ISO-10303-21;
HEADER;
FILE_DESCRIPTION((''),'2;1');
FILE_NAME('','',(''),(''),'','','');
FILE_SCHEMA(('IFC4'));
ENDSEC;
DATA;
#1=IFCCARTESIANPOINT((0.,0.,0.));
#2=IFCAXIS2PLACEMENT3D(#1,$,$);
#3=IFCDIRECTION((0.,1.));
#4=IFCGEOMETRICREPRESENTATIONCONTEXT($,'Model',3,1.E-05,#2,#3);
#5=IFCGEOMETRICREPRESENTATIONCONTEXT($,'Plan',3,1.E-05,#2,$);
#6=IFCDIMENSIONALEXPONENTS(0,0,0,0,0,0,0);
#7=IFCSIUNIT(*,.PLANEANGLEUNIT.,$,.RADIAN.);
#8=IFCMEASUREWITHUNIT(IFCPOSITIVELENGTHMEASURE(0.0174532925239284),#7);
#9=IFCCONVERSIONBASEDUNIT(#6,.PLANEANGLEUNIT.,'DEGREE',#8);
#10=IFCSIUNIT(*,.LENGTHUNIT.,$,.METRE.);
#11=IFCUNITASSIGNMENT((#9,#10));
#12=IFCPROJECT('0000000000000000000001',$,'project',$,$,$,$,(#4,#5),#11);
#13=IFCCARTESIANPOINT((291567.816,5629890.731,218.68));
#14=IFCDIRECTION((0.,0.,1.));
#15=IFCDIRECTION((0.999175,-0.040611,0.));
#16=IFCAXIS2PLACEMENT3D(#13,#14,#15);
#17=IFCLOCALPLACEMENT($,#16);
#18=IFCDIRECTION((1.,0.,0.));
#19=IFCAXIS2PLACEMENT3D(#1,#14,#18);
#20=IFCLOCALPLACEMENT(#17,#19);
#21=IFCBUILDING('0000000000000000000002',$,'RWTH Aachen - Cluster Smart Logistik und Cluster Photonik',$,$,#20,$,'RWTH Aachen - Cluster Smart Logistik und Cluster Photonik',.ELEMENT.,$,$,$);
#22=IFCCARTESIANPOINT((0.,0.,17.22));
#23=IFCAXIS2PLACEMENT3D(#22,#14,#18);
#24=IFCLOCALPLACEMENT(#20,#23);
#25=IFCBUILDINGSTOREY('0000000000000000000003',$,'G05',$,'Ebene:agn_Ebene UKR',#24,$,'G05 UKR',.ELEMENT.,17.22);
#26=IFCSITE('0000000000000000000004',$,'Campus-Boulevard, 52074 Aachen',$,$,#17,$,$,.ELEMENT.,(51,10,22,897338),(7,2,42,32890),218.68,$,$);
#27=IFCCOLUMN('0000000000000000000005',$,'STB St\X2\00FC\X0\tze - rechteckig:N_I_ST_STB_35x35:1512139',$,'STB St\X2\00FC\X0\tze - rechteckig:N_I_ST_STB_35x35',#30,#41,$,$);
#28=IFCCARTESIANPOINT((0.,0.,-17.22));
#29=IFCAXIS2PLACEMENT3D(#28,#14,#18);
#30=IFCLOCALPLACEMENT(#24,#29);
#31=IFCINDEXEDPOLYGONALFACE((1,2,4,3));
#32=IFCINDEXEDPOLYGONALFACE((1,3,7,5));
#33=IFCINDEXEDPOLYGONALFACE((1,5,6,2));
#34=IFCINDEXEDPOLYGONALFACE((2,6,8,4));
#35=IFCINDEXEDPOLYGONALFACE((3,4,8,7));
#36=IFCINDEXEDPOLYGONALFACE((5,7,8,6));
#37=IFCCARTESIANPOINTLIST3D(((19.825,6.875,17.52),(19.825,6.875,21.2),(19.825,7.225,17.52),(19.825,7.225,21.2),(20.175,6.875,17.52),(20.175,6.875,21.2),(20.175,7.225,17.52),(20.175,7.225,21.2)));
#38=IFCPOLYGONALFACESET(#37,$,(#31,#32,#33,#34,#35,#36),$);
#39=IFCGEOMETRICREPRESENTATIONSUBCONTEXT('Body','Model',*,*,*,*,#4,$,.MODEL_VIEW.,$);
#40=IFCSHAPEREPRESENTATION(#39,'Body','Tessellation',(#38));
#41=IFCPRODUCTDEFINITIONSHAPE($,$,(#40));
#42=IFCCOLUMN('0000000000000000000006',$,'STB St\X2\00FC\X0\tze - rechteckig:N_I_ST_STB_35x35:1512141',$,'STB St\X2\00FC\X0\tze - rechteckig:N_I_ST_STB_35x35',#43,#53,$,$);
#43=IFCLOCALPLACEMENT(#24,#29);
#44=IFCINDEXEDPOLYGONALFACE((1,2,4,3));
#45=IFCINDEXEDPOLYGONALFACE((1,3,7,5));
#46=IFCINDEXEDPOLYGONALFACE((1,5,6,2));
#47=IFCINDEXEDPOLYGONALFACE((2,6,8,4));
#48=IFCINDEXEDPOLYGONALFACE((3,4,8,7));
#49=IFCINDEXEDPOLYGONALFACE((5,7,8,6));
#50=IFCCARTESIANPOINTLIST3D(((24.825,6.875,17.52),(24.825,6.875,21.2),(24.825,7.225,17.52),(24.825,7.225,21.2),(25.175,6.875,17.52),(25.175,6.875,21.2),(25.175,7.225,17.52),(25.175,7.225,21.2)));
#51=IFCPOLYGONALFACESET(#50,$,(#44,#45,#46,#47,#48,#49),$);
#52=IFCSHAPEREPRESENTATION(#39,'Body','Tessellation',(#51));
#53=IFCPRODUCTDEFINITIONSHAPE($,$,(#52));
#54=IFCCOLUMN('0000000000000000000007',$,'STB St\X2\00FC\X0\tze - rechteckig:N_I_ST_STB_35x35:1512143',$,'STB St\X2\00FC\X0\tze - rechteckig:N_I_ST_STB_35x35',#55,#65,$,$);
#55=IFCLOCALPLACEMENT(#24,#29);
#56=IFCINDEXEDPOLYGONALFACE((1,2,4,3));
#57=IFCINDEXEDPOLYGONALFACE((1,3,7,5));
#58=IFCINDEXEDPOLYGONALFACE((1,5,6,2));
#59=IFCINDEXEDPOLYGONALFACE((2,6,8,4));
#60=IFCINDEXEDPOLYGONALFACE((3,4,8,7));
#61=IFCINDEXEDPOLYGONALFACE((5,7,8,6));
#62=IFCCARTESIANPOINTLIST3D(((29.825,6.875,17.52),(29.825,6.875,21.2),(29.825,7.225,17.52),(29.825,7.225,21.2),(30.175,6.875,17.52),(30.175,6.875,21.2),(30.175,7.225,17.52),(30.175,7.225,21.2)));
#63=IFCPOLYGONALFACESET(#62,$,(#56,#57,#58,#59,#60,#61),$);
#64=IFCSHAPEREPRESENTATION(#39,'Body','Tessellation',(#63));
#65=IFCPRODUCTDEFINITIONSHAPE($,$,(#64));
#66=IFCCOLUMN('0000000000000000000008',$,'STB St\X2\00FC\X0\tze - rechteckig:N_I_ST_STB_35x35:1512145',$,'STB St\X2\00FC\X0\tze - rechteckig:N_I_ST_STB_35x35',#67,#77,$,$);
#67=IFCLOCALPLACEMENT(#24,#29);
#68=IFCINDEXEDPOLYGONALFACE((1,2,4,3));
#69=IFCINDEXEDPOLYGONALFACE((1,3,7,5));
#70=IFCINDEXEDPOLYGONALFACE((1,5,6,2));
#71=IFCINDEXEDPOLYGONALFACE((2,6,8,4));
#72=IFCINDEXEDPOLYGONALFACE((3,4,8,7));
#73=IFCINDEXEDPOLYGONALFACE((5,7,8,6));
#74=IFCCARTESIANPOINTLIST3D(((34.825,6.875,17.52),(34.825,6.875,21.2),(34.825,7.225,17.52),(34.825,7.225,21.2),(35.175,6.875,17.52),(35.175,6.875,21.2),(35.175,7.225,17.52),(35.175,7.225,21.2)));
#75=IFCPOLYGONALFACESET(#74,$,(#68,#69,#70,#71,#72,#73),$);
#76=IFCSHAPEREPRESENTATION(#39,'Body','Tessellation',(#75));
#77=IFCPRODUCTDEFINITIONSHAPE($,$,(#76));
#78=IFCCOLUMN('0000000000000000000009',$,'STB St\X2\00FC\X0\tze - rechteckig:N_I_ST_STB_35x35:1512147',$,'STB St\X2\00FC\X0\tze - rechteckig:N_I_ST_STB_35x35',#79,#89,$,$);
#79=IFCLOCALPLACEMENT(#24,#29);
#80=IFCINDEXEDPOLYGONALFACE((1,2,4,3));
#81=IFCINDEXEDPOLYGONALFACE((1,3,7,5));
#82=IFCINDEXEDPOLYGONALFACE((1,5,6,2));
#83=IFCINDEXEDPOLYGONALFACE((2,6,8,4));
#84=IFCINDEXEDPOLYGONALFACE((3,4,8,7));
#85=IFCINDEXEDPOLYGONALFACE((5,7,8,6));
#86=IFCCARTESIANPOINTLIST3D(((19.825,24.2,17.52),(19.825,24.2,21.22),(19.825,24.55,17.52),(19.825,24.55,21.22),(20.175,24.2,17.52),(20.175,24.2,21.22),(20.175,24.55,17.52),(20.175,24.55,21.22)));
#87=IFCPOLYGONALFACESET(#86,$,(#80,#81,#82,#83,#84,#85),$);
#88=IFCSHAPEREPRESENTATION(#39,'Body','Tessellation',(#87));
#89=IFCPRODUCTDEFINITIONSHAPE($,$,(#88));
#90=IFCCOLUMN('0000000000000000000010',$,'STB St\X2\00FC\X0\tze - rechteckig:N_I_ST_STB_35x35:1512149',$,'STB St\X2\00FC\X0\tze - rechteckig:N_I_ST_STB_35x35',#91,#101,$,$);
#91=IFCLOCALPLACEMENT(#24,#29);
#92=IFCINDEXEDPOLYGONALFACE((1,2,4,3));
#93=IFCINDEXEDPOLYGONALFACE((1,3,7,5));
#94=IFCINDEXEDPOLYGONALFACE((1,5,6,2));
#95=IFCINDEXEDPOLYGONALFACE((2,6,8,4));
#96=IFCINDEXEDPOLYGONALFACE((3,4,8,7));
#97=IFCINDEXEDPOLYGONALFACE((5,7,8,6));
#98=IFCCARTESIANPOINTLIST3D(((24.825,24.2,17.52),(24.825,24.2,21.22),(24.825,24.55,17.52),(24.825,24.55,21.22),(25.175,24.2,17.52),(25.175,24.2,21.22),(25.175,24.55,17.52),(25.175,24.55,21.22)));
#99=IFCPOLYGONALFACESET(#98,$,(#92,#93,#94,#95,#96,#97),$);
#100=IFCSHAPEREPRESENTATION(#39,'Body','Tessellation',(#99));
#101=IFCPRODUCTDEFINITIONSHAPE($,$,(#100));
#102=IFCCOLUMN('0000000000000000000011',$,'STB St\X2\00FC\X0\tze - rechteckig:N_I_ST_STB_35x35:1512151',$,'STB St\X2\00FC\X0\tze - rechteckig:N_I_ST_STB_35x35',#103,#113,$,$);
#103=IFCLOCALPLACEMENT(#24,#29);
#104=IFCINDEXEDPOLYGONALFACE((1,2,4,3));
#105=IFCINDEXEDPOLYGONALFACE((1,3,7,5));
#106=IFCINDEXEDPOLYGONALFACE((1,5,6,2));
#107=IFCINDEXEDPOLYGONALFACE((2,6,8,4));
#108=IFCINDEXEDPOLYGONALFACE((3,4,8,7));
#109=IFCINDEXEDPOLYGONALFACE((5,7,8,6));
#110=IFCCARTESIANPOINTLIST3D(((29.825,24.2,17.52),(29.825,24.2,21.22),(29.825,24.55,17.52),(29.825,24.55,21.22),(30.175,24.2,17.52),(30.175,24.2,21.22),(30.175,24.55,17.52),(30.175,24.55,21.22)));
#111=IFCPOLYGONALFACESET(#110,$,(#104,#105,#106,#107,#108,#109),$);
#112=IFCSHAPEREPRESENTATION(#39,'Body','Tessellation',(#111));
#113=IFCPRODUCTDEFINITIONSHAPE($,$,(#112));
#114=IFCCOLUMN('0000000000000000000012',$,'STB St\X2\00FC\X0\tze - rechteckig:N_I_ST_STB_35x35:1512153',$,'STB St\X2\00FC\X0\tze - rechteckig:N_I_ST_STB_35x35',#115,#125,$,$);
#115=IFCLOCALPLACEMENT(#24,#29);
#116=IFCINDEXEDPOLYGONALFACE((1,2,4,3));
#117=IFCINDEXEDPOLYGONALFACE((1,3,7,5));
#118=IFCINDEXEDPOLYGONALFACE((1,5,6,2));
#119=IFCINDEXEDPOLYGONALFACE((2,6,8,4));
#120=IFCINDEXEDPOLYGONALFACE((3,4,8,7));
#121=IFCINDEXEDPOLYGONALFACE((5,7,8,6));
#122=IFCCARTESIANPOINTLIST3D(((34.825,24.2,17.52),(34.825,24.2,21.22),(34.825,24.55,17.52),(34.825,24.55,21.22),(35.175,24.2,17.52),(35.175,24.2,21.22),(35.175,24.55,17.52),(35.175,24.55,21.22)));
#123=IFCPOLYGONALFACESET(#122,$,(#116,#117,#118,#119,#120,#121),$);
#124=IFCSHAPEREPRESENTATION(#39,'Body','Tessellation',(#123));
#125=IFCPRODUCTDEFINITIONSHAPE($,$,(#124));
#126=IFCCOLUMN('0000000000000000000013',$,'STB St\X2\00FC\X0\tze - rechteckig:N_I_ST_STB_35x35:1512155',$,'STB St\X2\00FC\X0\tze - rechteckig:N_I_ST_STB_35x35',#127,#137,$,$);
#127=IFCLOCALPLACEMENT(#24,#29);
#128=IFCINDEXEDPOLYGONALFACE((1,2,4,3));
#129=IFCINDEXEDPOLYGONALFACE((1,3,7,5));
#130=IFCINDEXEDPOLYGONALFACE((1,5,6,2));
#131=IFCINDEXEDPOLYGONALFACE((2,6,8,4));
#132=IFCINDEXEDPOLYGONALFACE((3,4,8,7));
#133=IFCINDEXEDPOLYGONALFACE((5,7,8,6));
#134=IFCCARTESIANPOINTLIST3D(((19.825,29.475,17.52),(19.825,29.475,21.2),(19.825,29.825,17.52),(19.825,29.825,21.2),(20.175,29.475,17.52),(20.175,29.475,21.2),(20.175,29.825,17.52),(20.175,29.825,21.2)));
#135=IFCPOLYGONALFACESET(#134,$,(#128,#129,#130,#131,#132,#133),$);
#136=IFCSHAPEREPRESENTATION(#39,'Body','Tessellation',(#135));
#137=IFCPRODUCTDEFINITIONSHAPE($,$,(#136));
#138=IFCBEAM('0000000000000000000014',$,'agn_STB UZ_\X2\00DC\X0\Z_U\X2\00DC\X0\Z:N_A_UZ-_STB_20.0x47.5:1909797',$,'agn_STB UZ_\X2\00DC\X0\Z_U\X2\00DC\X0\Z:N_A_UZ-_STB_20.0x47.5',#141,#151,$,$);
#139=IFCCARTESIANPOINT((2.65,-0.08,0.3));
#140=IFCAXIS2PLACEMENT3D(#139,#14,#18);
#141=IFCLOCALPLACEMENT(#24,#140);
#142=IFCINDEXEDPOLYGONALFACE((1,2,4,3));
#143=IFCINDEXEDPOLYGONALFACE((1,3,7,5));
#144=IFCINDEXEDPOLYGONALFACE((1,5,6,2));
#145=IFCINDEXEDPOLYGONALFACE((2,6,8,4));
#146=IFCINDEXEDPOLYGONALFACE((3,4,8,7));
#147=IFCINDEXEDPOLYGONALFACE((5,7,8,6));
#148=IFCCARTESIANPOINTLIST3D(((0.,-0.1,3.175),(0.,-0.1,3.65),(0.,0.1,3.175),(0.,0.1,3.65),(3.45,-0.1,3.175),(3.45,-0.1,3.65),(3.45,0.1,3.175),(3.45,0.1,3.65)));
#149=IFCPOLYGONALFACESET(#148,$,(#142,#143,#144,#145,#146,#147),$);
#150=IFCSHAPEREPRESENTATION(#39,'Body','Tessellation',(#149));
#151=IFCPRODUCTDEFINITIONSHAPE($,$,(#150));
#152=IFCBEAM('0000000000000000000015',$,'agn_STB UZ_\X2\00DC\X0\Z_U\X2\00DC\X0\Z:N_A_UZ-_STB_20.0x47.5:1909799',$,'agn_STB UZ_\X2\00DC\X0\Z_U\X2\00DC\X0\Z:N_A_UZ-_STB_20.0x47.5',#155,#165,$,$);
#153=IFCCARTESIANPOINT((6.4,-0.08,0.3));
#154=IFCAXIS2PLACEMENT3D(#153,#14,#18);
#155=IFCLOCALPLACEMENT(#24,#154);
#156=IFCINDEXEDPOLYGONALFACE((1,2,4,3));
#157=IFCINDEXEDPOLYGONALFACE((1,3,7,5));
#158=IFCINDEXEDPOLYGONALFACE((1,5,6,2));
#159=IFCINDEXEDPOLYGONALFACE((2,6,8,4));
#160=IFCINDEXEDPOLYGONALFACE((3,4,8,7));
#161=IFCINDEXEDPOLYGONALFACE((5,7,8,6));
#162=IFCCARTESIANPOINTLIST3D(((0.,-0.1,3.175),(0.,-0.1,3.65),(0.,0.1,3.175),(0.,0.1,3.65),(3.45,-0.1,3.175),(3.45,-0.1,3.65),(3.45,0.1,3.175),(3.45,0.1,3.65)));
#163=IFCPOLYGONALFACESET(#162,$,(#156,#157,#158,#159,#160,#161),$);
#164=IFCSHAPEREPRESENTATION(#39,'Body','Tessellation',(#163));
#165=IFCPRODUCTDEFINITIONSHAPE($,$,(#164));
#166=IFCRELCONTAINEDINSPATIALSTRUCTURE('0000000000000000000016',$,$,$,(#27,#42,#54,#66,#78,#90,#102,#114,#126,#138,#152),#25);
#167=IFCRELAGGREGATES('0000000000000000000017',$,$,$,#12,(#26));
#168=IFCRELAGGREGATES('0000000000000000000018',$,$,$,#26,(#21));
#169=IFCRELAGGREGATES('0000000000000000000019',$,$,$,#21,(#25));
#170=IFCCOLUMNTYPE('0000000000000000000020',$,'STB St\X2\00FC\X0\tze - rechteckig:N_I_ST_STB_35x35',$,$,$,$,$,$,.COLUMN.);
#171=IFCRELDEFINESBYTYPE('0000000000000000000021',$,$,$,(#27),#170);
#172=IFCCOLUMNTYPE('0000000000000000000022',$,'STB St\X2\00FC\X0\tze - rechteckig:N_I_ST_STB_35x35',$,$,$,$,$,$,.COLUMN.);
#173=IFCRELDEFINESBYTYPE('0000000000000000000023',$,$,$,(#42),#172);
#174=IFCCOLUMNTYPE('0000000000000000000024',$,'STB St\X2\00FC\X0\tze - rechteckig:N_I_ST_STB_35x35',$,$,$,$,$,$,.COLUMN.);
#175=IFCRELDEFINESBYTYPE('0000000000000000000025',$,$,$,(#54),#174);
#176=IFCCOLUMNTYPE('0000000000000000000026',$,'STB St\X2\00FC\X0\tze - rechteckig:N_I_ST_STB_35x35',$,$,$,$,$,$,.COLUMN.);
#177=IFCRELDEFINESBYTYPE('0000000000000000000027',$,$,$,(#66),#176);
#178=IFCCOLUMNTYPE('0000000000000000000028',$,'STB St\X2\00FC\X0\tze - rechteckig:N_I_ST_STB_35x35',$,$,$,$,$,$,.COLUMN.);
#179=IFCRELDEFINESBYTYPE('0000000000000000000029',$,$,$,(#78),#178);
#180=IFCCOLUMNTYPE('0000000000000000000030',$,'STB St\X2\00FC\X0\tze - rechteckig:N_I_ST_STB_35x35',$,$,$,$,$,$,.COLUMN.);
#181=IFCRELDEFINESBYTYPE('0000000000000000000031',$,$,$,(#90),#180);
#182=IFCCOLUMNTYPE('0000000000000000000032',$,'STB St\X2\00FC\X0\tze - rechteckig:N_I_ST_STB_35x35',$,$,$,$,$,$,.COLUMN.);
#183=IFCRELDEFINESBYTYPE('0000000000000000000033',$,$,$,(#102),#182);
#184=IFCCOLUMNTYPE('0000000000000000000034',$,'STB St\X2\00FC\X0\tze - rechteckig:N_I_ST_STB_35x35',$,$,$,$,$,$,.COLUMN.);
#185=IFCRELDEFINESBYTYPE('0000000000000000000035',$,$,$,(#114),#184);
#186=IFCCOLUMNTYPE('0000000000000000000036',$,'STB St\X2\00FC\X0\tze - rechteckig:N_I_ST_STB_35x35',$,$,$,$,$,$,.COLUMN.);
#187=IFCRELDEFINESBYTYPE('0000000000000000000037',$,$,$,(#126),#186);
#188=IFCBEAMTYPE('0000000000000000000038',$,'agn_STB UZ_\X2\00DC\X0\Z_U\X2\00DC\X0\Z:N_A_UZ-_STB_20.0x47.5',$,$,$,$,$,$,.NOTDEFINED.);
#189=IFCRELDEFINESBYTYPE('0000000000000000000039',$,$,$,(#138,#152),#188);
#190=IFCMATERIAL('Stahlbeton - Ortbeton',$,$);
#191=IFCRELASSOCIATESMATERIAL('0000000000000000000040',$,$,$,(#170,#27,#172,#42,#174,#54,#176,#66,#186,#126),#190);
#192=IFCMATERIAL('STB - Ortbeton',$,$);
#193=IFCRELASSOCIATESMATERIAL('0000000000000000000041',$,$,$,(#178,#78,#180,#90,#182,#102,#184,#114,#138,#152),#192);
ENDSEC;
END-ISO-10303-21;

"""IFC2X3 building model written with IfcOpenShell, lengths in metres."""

from ifc_helpers import new_model, entity, si_unit, converted_unit, direction, frame, frame_2d, origin, origin_with_axes, origin_2d_with_axis, place, context, subcontext, project, spatial, rectangle, extrude, source, transform, mapped, material, type_object, element, save


model = new_model("IFC2X3")

# Units and contexts
model_context = context("Model", 3, precision=1e-05, world=origin(), true_north=direction((0.0, 1.0)))
plan_context = context("Plan", 3, precision=1e-05, world=origin())
body_context = subcontext(model_context, "Body", "Model", "MODEL_VIEW")
ifc_project = project(units=[converted_unit("PLANEANGLEUNIT", "DEGREE", entity("IfcPositiveLengthMeasure", 0.0174532925239284), si_unit("PLANEANGLEUNIT", "RADIAN"), dimensions=[0, 0, 0, 0, 0, 0, 0]), si_unit("LENGTHUNIT", "METRE")], contexts=[model_context, plan_context])

# Site, building, storey
site_placement = place(None, frame((291567.816, 5629890.731, 218.68), z_axis=(0.0, 0.0, 1.0), x_axis=(0.999175, -0.040611, 0.0)))
site = spatial("IfcSite", under=ifc_project, at=site_placement, Name="Campus-Boulevard, 52074 Aachen", CompositionType="ELEMENT", RefLatitude=(51, 10, 22, 897338), RefLongitude=(7, 2, 42, 32890), RefElevation=218.68)
building_placement = place(site_placement, origin_with_axes())
building = spatial("IfcBuilding", under=site, at=building_placement, Name="RWTH Aachen - Cluster Smart Logistik und Cluster Photonik", LongName="RWTH Aachen - Cluster Smart Logistik und Cluster Photonik", CompositionType="ELEMENT")
storey_placement = place(building_placement, frame((0.0, 0.0, 17.22), z_axis=(0.0, 0.0, 1.0), x_axis=(1.0, 0.0, 0.0)))
storey = spatial("IfcBuildingStorey", under=building, at=storey_placement, Name="G05", ObjectType="Ebene:agn_Ebene UKR", LongName="G05 UKR", CompositionType="ELEMENT", Elevation=17.22)

# Columns
ifc_material_1 = material(Name="STB - Ortbeton")
ifc_material_2 = material(Name="Stahlbeton - Ortbeton")
column_type_1 = type_object("IfcColumnType", Name="STB Stütze - rechteckig:N_I_ST_STB_35x35", PredefinedType="COLUMN", material=ifc_material_2)
shared_shape_1 = source(origin(), body_context, "Body", "SweptSolid", [
    extrude(rectangle(XDim=0.35, YDim=0.35, at=origin_2d_with_axis()), frame((20.0, 7.05, 17.52), z_axis=(0.0, 0.0, 1.0), x_axis=(0.0, -1.0, 0.0)), (0.0, 0.0, 1.0), 3.68),
])
column_1_placement = place(storey_placement, frame((0.0, 0.0, -17.22), z_axis=(0.0, 0.0, 1.0), x_axis=(1.0, 0.0, 0.0)))
element("IfcColumn", 1, at=column_1_placement, inside=storey, type_object=column_type_1, material=ifc_material_2, Name="STB Stütze - rechteckig:N_I_ST_STB_35x35:1512139", ObjectType="STB Stütze - rechteckig:N_I_ST_STB_35x35", context=body_context, shape_type="MappedRepresentation", body=[
    mapped(shared_shape_1, transform((0.0, 0.0, 0.0), scale=1.0)),
])
column_type_2 = type_object("IfcColumnType", Name="STB Stütze - rechteckig:N_I_ST_STB_35x35", PredefinedType="COLUMN", material=ifc_material_2)
shared_shape_2 = source(origin(), body_context, "Body", "SweptSolid", [
    extrude(rectangle(XDim=0.35, YDim=0.35, at=origin_2d_with_axis()), frame((25.0, 7.05, 17.52), z_axis=(0.0, 0.0, 1.0), x_axis=(0.0, -1.0, 0.0)), (0.0, 0.0, 1.0), 3.68),
])
column_2_placement = place(storey_placement, frame((0.0, 0.0, -17.22), z_axis=(0.0, 0.0, 1.0), x_axis=(1.0, 0.0, 0.0)))
element("IfcColumn", 2, at=column_2_placement, inside=storey, type_object=column_type_2, material=ifc_material_2, Name="STB Stütze - rechteckig:N_I_ST_STB_35x35:1512141", ObjectType="STB Stütze - rechteckig:N_I_ST_STB_35x35", context=body_context, shape_type="MappedRepresentation", body=[
    mapped(shared_shape_2, transform((0.0, 0.0, 0.0), scale=1.0)),
])
column_type_3 = type_object("IfcColumnType", Name="STB Stütze - rechteckig:N_I_ST_STB_35x35", PredefinedType="COLUMN", material=ifc_material_2)
shared_shape_3 = source(origin(), body_context, "Body", "SweptSolid", [
    extrude(rectangle(XDim=0.35, YDim=0.35, at=origin_2d_with_axis()), frame((30.0, 7.05, 17.52), z_axis=(0.0, 0.0, 1.0), x_axis=(0.0, -1.0, 0.0)), (0.0, 0.0, 1.0), 3.68),
])
column_3_placement = place(storey_placement, frame((0.0, 0.0, -17.22), z_axis=(0.0, 0.0, 1.0), x_axis=(1.0, 0.0, 0.0)))
element("IfcColumn", 3, at=column_3_placement, inside=storey, type_object=column_type_3, material=ifc_material_2, Name="STB Stütze - rechteckig:N_I_ST_STB_35x35:1512143", ObjectType="STB Stütze - rechteckig:N_I_ST_STB_35x35", context=body_context, shape_type="MappedRepresentation", body=[
    mapped(shared_shape_3, transform((0.0, 0.0, 0.0), scale=1.0)),
])
column_type_4 = type_object("IfcColumnType", Name="STB Stütze - rechteckig:N_I_ST_STB_35x35", PredefinedType="COLUMN", material=ifc_material_2)
shared_shape_4 = source(origin(), body_context, "Body", "SweptSolid", [
    extrude(rectangle(XDim=0.35, YDim=0.35, at=frame_2d((0.0, 0.0), x_axis=(1.0, 0.0))), frame((35.0, 7.05, 17.52), z_axis=(0.0, 0.0, 1.0), x_axis=(0.0, -1.0, 0.0)), (0.0, 0.0, 1.0), 3.68),
])
column_4_placement = place(storey_placement, frame((0.0, 0.0, -17.22), z_axis=(0.0, 0.0, 1.0), x_axis=(1.0, 0.0, 0.0)))
element("IfcColumn", 4, at=column_4_placement, inside=storey, type_object=column_type_4, material=ifc_material_2, Name="STB Stütze - rechteckig:N_I_ST_STB_35x35:1512145", ObjectType="STB Stütze - rechteckig:N_I_ST_STB_35x35", context=body_context, shape_type="MappedRepresentation", body=[
    mapped(shared_shape_4, transform((0.0, 0.0, 0.0), scale=1.0)),
])
column_type_5 = type_object("IfcColumnType", Name="STB Stütze - rechteckig:N_I_ST_STB_35x35", PredefinedType="COLUMN", material=ifc_material_1)
shared_shape_5 = source(origin(), body_context, "Body", "SweptSolid", [
    extrude(rectangle(XDim=0.35, YDim=0.35, at=origin_2d_with_axis()), frame((20.0, 24.375, 17.52), z_axis=(0.0, 0.0, 1.0), x_axis=(0.0, -1.0, 0.0)), (0.0, 0.0, 1.0), 3.7),
])
column_5_placement = place(storey_placement, frame((0.0, 0.0, -17.22), z_axis=(0.0, 0.0, 1.0), x_axis=(1.0, 0.0, 0.0)))
element("IfcColumn", 5, at=column_5_placement, inside=storey, type_object=column_type_5, material=ifc_material_1, Name="STB Stütze - rechteckig:N_I_ST_STB_35x35:1512147", ObjectType="STB Stütze - rechteckig:N_I_ST_STB_35x35", context=body_context, shape_type="MappedRepresentation", body=[
    mapped(shared_shape_5, transform((0.0, 0.0, 0.0), scale=1.0)),
])
column_type_6 = type_object("IfcColumnType", Name="STB Stütze - rechteckig:N_I_ST_STB_35x35", PredefinedType="COLUMN", material=ifc_material_1)
shared_shape_6 = source(origin(), body_context, "Body", "SweptSolid", [
    extrude(rectangle(XDim=0.35, YDim=0.35, at=origin_2d_with_axis()), frame((25.0, 24.375, 17.52), z_axis=(0.0, 0.0, 1.0), x_axis=(0.0, -1.0, 0.0)), (0.0, 0.0, 1.0), 3.7),
])
column_6_placement = place(storey_placement, frame((0.0, 0.0, -17.22), z_axis=(0.0, 0.0, 1.0), x_axis=(1.0, 0.0, 0.0)))
element("IfcColumn", 6, at=column_6_placement, inside=storey, type_object=column_type_6, material=ifc_material_1, Name="STB Stütze - rechteckig:N_I_ST_STB_35x35:1512149", ObjectType="STB Stütze - rechteckig:N_I_ST_STB_35x35", context=body_context, shape_type="MappedRepresentation", body=[
    mapped(shared_shape_6, transform((0.0, 0.0, 0.0), scale=1.0)),
])
column_type_7 = type_object("IfcColumnType", Name="STB Stütze - rechteckig:N_I_ST_STB_35x35", PredefinedType="COLUMN", material=ifc_material_1)
shared_shape_7 = source(origin(), body_context, "Body", "SweptSolid", [
    extrude(rectangle(XDim=0.35, YDim=0.35, at=origin_2d_with_axis()), frame((30.0, 24.375, 17.52), z_axis=(0.0, 0.0, 1.0), x_axis=(0.0, -1.0, 0.0)), (0.0, 0.0, 1.0), 3.7),
])
column_7_placement = place(storey_placement, frame((0.0, 0.0, -17.22), z_axis=(0.0, 0.0, 1.0), x_axis=(1.0, 0.0, 0.0)))
element("IfcColumn", 7, at=column_7_placement, inside=storey, type_object=column_type_7, material=ifc_material_1, Name="STB Stütze - rechteckig:N_I_ST_STB_35x35:1512151", ObjectType="STB Stütze - rechteckig:N_I_ST_STB_35x35", context=body_context, shape_type="MappedRepresentation", body=[
    mapped(shared_shape_7, transform((0.0, 0.0, 0.0), scale=1.0)),
])
column_type_8 = type_object("IfcColumnType", Name="STB Stütze - rechteckig:N_I_ST_STB_35x35", PredefinedType="COLUMN", material=ifc_material_1)
shared_shape_8 = source(origin(), body_context, "Body", "SweptSolid", [
    extrude(rectangle(XDim=0.35, YDim=0.35, at=frame_2d((0.0, 0.0), x_axis=(1.0, 0.0))), frame((35.0, 24.375, 17.52), z_axis=(0.0, 0.0, 1.0), x_axis=(0.0, -1.0, 0.0)), (0.0, 0.0, 1.0), 3.7),
])
column_8_placement = place(storey_placement, frame((0.0, 0.0, -17.22), z_axis=(0.0, 0.0, 1.0), x_axis=(1.0, 0.0, 0.0)))
element("IfcColumn", 8, at=column_8_placement, inside=storey, type_object=column_type_8, material=ifc_material_1, Name="STB Stütze - rechteckig:N_I_ST_STB_35x35:1512153", ObjectType="STB Stütze - rechteckig:N_I_ST_STB_35x35", context=body_context, shape_type="MappedRepresentation", body=[
    mapped(shared_shape_8, transform((0.0, 0.0, 0.0), scale=1.0)),
])
column_type_9 = type_object("IfcColumnType", Name="STB Stütze - rechteckig:N_I_ST_STB_35x35", PredefinedType="COLUMN", material=ifc_material_2)
shared_shape_9 = source(origin(), body_context, "Body", "SweptSolid", [
    extrude(rectangle(XDim=0.35, YDim=0.35, at=frame_2d((0.0, 0.0), x_axis=(1.0, 0.0))), frame((20.0, 29.65, 17.52), z_axis=(0.0, 0.0, 1.0), x_axis=(0.0, -1.0, 0.0)), (0.0, 0.0, 1.0), 3.68),
])
column_9_placement = place(storey_placement, frame((0.0, 0.0, -17.22), z_axis=(0.0, 0.0, 1.0), x_axis=(1.0, 0.0, 0.0)))
element("IfcColumn", 9, at=column_9_placement, inside=storey, type_object=column_type_9, material=ifc_material_2, Name="STB Stütze - rechteckig:N_I_ST_STB_35x35:1512155", ObjectType="STB Stütze - rechteckig:N_I_ST_STB_35x35", context=body_context, shape_type="MappedRepresentation", body=[
    mapped(shared_shape_9, transform((0.0, 0.0, 0.0), scale=1.0)),
])

# Beams
beam_type_1 = type_object("IfcBeamType", Name="agn_STB UZ_ÜZ_UÜZ:N_A_UZ-_STB_20.0x47.5", PredefinedType="NOTDEFINED")
for number, where, z_axis, x_axis, name in (
    (10, (2.65, -0.08, 0.3), (0.0, 0.0, 1.0), (1.0, 0.0, 0.0), "agn_STB UZ_ÜZ_UÜZ:N_A_UZ-_STB_20.0x47.5:1909797"),
    (11, (6.4, -0.08, 0.3), (0.0, 0.0, 1.0), (1.0, 0.0, 0.0), "agn_STB UZ_ÜZ_UÜZ:N_A_UZ-_STB_20.0x47.5:1909799"),
):
    element("IfcBeam", number, at=place(storey_placement, frame(where, z_axis=z_axis, x_axis=x_axis)), inside=storey, type_object=beam_type_1, material=ifc_material_1, Name=name, ObjectType="agn_STB UZ_ÜZ_UÜZ:N_A_UZ-_STB_20.0x47.5", context=body_context, shape_type="SweptSolid", body=[
        extrude(rectangle(XDim=0.475, YDim=0.2, at=frame_2d((0.0, 0.0), x_axis=(1.0, 0.0))), frame((0.0, 0.0, 3.4125), z_axis=(1.0, 0.0, 0.0), x_axis=(0.0, 0.0, -1.0)), (0.0, 0.0, 1.0), 3.45),
    ])

save(model, "model.ifc")
